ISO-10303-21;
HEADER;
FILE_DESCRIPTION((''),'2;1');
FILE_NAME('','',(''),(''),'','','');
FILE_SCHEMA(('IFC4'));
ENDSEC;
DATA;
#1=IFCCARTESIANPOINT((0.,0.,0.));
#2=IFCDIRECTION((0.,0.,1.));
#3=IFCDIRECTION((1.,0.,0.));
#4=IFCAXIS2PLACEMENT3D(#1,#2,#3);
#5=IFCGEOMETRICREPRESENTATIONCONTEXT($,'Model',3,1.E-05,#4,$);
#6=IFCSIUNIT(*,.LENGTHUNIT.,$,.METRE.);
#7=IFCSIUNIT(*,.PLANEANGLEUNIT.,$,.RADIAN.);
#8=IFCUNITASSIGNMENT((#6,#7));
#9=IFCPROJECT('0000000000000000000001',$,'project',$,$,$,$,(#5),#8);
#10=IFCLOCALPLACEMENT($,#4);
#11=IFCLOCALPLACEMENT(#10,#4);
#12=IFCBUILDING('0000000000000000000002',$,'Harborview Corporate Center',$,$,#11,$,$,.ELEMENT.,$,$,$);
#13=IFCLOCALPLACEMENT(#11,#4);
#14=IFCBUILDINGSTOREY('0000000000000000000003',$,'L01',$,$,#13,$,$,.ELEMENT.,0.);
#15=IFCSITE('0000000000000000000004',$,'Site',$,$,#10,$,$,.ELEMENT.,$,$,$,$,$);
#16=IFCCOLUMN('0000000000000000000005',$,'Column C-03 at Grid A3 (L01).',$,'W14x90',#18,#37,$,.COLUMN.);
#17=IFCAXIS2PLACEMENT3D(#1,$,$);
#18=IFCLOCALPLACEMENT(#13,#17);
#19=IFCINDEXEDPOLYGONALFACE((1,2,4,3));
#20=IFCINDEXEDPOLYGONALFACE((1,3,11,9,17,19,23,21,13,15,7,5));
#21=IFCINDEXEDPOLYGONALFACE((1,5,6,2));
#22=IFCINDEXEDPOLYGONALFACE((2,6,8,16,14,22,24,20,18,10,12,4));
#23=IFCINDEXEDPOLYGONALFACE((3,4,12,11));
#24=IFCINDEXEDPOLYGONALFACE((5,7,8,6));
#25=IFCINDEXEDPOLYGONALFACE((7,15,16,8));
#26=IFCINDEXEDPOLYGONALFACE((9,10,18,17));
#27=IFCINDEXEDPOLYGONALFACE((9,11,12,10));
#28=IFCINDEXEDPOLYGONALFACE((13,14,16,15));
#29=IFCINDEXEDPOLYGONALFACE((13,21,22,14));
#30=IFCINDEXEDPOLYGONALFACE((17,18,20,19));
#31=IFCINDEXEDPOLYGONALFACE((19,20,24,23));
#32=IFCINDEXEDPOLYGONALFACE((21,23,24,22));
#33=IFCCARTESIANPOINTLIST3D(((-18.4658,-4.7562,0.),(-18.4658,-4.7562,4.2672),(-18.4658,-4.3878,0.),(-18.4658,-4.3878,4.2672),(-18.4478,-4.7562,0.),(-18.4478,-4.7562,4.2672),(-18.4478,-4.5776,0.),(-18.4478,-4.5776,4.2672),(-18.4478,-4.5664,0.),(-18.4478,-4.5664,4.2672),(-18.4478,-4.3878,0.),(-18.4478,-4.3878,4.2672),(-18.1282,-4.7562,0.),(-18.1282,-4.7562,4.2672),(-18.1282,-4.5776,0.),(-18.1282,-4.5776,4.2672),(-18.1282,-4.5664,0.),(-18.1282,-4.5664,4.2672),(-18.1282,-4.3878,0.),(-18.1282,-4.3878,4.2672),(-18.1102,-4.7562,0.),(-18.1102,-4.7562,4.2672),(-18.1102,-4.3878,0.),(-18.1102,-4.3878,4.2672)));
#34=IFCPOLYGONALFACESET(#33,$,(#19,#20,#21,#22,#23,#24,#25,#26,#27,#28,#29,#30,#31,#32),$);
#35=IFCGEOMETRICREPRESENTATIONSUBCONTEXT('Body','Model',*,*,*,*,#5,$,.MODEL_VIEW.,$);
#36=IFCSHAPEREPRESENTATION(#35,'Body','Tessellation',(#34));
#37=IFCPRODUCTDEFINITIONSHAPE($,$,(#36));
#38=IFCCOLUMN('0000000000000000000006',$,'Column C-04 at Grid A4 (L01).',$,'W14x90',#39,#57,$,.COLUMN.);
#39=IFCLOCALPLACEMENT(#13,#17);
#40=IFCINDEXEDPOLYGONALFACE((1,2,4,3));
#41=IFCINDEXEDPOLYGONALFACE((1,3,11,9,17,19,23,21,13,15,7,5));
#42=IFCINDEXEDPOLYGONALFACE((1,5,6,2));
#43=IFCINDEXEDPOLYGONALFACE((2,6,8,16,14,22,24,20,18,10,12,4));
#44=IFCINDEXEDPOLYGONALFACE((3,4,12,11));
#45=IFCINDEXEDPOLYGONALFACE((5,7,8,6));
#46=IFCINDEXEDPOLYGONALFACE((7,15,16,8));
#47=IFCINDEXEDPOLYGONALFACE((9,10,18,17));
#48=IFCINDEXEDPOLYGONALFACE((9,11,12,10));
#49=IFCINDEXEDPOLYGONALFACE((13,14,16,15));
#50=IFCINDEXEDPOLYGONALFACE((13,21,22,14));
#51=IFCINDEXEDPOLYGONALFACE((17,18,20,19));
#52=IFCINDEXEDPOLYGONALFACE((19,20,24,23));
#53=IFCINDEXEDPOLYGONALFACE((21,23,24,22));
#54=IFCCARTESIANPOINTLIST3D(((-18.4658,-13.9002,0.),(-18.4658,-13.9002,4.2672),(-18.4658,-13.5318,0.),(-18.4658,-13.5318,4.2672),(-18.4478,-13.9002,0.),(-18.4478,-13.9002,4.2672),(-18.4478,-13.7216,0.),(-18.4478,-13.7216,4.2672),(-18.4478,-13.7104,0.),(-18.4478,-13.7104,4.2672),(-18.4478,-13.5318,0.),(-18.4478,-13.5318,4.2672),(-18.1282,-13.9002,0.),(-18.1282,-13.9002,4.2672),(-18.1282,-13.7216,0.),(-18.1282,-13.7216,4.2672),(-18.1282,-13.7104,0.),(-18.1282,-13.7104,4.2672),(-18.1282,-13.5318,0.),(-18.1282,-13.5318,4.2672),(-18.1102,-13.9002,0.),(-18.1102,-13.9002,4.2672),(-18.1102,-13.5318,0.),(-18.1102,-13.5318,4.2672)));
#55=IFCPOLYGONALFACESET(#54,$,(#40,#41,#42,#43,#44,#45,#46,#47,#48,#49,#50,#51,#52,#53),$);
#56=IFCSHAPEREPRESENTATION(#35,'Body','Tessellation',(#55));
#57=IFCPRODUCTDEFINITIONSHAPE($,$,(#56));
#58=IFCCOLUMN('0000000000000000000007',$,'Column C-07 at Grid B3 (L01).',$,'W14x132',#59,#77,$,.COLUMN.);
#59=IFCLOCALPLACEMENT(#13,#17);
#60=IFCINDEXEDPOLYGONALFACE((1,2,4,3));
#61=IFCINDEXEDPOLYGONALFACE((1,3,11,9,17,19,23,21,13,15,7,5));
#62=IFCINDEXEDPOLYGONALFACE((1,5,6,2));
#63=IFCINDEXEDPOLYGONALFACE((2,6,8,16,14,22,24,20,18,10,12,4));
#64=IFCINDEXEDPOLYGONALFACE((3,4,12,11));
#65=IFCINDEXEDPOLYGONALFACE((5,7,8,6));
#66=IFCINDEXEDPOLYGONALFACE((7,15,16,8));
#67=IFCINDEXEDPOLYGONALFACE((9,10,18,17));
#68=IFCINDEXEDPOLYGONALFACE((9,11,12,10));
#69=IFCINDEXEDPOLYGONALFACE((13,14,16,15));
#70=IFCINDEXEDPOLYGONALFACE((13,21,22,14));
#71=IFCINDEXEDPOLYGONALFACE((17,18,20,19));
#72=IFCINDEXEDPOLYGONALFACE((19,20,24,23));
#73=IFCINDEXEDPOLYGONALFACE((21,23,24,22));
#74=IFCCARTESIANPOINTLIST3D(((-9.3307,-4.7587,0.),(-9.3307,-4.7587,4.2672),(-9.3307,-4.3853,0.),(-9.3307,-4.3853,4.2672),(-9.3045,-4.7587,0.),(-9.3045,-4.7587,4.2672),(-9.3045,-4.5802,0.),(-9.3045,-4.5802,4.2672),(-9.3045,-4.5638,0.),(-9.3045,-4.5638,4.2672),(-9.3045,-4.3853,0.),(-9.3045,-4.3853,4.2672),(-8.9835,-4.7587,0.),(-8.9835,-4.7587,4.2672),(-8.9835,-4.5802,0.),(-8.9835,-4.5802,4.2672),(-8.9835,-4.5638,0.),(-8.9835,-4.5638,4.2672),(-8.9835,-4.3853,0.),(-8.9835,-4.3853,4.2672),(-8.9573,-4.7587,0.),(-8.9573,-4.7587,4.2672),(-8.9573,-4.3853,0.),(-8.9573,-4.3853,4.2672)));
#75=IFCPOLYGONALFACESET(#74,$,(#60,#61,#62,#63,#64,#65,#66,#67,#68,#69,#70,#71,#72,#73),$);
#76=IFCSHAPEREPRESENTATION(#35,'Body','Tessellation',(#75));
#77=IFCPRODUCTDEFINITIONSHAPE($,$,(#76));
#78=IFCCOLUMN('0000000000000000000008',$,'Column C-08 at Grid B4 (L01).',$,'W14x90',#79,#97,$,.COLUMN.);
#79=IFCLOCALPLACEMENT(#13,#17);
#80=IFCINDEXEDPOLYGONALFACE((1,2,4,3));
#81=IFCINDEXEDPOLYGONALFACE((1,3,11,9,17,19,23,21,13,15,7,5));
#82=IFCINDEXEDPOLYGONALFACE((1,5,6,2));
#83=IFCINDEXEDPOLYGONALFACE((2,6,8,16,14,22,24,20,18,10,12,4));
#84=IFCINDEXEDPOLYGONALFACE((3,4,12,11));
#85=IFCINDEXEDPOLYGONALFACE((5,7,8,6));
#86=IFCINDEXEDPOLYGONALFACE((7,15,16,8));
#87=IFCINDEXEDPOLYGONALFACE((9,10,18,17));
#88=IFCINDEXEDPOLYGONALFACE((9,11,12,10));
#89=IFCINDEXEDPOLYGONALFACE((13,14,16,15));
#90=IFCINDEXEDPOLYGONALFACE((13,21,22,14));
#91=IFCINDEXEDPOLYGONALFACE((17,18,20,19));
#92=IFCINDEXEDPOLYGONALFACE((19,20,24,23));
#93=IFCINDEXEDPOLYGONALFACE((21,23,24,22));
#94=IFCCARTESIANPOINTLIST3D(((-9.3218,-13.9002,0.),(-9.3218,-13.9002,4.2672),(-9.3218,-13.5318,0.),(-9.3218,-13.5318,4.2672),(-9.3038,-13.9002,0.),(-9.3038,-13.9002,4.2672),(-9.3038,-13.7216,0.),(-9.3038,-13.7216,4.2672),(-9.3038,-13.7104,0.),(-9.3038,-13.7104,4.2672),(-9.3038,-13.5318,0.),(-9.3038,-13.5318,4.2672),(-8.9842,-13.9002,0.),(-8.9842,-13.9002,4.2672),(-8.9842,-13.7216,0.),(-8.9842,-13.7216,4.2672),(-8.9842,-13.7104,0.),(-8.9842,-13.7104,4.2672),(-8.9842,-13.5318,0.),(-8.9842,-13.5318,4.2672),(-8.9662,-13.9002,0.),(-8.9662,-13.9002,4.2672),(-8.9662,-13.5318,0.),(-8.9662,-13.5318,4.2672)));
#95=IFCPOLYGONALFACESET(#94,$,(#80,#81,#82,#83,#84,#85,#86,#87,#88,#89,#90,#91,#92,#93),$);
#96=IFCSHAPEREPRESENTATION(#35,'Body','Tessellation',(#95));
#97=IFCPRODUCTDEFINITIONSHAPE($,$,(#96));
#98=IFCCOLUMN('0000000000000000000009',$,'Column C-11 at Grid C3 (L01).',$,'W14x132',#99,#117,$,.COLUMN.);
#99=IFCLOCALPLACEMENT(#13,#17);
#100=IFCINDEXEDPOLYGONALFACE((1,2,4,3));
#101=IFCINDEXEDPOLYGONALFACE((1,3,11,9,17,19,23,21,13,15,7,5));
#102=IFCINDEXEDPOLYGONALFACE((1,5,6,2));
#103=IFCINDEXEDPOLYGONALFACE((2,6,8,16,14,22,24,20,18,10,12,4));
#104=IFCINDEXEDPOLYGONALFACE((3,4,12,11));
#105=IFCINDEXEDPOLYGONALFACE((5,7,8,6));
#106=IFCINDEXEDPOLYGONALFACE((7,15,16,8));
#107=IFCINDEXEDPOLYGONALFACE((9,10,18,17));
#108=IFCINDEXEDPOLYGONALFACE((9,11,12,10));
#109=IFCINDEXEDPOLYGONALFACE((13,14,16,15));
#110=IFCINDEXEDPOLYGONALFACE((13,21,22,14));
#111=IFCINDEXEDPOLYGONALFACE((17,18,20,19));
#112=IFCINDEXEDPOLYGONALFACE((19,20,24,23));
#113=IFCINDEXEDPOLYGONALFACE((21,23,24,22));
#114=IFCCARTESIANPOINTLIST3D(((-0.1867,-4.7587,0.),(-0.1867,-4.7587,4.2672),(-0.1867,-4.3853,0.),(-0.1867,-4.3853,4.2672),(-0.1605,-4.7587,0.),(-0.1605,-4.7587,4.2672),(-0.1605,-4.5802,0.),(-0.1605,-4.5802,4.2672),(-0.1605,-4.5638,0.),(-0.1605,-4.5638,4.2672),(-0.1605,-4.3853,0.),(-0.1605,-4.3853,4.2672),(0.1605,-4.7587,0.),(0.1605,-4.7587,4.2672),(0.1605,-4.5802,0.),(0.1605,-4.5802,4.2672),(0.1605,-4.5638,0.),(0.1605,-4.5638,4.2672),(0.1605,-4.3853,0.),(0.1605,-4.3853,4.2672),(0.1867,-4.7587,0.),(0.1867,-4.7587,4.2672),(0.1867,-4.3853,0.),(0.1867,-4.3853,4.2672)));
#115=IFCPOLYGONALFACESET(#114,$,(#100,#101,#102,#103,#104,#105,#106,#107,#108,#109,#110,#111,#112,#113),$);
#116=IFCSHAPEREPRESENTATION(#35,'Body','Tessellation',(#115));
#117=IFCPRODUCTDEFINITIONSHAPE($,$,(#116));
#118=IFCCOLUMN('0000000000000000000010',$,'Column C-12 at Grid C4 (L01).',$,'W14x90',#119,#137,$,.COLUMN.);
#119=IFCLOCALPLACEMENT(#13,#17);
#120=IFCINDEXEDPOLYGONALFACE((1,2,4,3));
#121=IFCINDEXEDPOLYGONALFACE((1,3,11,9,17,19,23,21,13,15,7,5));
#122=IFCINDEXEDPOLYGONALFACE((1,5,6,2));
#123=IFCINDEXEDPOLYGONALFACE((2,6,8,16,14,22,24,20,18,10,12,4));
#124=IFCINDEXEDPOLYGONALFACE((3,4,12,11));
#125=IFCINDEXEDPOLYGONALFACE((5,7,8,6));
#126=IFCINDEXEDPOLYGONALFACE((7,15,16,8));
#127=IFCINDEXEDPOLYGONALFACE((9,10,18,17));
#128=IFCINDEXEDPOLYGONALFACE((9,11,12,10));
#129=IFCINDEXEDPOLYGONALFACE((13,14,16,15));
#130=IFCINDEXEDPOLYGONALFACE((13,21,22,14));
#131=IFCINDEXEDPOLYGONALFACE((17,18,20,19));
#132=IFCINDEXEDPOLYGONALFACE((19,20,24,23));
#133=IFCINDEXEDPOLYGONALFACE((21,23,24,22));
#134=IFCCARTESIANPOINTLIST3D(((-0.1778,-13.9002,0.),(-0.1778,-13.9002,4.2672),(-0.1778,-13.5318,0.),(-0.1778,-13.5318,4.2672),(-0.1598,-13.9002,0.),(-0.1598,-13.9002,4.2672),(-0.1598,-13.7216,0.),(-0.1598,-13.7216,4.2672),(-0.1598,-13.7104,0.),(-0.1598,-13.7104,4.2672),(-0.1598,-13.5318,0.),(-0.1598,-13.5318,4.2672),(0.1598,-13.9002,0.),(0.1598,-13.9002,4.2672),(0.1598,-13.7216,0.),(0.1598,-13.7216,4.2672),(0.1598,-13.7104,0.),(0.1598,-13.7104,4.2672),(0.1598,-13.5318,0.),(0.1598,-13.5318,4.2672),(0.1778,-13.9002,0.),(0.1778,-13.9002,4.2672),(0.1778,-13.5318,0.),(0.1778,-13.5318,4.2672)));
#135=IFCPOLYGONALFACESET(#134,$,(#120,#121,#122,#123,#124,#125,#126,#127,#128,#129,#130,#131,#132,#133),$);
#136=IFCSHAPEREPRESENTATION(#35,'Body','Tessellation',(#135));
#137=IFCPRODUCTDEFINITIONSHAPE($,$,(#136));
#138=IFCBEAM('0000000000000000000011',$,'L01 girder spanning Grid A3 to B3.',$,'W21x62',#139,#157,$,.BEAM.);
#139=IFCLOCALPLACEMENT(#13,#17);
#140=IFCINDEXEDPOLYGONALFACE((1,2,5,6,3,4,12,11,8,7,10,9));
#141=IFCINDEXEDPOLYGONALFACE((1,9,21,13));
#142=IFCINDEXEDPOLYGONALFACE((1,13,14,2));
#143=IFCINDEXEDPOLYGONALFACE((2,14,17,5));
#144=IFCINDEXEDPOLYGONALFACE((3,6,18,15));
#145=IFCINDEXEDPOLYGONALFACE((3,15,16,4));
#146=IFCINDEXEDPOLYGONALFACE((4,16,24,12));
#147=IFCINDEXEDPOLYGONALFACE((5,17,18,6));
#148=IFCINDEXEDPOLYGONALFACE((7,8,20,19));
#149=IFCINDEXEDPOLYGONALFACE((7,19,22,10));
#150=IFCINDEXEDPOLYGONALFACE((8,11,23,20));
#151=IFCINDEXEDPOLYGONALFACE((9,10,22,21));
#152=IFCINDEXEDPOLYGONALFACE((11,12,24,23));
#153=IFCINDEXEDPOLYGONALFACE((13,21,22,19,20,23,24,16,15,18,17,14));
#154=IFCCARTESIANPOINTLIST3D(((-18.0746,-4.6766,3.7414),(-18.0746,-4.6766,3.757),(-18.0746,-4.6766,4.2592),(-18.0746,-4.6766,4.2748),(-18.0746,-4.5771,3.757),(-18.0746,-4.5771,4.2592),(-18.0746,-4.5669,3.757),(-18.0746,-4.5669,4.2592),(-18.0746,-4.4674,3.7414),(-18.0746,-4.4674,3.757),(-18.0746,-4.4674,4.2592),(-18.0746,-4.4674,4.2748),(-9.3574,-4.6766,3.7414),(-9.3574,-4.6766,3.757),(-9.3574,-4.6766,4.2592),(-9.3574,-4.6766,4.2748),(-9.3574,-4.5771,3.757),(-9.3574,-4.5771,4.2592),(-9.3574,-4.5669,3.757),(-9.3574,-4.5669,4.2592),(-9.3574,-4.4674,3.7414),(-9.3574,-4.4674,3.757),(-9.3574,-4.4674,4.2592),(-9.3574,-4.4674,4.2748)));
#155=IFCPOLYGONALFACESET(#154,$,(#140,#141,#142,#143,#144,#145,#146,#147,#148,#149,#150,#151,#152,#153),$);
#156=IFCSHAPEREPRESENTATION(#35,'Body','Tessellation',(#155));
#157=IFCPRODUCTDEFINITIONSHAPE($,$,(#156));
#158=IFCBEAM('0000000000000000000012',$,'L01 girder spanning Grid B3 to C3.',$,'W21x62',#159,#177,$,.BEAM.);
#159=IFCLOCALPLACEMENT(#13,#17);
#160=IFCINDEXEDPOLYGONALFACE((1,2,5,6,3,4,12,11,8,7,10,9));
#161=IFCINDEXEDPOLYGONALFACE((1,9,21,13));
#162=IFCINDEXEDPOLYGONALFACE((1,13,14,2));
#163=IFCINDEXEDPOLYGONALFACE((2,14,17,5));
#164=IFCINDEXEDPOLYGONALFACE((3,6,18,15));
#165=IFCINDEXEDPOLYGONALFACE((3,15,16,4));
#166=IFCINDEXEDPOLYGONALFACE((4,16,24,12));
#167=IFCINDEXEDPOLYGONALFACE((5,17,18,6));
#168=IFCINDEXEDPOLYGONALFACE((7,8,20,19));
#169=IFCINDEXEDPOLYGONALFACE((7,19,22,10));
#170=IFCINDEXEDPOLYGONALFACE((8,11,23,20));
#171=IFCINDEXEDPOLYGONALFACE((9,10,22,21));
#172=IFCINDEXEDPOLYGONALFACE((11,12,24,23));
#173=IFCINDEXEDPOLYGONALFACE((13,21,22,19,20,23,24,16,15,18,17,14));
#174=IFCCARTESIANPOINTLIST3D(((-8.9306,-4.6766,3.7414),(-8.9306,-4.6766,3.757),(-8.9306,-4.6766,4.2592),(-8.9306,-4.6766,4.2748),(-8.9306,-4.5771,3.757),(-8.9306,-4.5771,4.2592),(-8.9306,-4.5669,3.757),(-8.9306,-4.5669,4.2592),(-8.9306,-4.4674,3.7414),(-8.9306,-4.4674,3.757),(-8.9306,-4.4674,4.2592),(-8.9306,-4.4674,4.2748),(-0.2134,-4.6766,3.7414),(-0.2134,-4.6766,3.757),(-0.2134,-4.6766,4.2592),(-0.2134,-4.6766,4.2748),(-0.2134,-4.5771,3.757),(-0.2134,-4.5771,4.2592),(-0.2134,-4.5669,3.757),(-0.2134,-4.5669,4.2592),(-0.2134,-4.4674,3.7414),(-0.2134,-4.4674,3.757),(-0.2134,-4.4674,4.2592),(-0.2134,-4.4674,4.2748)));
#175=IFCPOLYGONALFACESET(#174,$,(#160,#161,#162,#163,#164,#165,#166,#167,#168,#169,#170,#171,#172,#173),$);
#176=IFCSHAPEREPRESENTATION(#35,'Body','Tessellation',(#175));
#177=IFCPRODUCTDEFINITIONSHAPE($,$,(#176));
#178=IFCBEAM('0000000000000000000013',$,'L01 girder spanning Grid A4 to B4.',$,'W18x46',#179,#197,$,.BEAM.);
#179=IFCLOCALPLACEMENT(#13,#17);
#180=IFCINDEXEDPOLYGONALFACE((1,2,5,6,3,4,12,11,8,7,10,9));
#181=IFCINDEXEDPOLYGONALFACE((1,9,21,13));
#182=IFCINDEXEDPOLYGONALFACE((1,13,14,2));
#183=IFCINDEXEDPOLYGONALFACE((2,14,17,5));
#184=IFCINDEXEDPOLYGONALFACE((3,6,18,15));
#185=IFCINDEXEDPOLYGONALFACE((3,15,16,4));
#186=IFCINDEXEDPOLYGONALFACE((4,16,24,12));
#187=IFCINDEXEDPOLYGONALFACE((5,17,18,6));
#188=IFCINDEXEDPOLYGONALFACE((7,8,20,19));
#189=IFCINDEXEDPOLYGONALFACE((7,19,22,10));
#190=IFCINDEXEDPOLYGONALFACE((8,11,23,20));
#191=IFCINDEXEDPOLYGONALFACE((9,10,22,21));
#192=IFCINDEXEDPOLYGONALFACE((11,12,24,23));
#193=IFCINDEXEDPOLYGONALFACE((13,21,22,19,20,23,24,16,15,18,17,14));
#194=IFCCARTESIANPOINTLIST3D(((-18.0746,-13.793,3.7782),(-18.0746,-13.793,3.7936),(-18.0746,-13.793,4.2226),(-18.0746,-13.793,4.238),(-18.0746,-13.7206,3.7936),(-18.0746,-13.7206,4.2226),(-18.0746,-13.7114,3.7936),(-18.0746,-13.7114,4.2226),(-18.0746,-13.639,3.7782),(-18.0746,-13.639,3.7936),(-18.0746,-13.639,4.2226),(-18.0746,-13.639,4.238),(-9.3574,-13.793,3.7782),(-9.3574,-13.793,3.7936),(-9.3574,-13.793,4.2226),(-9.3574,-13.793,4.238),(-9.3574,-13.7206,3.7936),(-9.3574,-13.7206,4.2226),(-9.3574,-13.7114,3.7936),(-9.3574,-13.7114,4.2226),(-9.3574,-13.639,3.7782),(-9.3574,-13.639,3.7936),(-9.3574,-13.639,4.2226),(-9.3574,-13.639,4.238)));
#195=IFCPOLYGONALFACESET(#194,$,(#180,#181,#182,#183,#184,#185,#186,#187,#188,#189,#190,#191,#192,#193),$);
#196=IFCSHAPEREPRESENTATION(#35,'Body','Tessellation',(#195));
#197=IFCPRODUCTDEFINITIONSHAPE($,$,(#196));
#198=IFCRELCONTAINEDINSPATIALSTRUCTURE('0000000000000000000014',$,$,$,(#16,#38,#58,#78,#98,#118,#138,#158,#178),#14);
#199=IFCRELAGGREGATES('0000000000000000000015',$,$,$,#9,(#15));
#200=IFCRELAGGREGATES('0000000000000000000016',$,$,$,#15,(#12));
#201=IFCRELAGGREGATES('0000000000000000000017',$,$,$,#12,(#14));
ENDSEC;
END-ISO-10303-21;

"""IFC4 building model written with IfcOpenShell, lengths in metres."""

from ifc_helpers import new_model, si_unit, frame, origin_with_axes, place, context, subcontext, project, spatial, i_section, extrude, element, save


model = new_model("IFC4")

# Units and contexts
model_context = context("Model", 3, precision=1e-05, world=origin_with_axes())
body_context = subcontext(model_context, "Body", "Model", "MODEL_VIEW")
ifc_project = project(units=[si_unit("LENGTHUNIT", "METRE"), si_unit("PLANEANGLEUNIT", "RADIAN")], contexts=[model_context])

# Site, building, storey
site_placement = place(None, origin_with_axes())
site = spatial("IfcSite", under=ifc_project, at=site_placement, Name="Site", CompositionType="ELEMENT")
building_placement = place(site_placement, origin_with_axes())
building = spatial("IfcBuilding", under=site, at=building_placement, Name="Harborview Corporate Center", CompositionType="ELEMENT")
storey_placement = place(building_placement, origin_with_axes())
storey = spatial("IfcBuildingStorey", under=building, at=storey_placement, Name="L01", CompositionType="ELEMENT", Elevation=0.0)

# Columns
for number, where, z_axis, x_axis, name in (
    (1, (-18.288, -4.572, 0.0), (0.0, 0.0, 1.0), (0.0, 1.0, 0.0), "Column C-03 at Grid A3 (L01)."),
    (2, (-18.288, -13.716, 0.0), (0.0, 0.0, 1.0), (0.0, 1.0, 0.0), "Column C-04 at Grid A4 (L01)."),
):
    element("IfcColumn", number, at=place(storey_placement, frame(where, z_axis=z_axis, x_axis=x_axis)), inside=storey, Name=name, ObjectType="W14x90", PredefinedType="COLUMN", context=body_context, shape_type="SweptSolid", body=[
        extrude(i_section(OverallWidth=0.3683, OverallDepth=0.3556, WebThickness=0.0112, FlangeThickness=0.018), origin_with_axes(), (0.0, 0.0, 1.0), 4.2672),
    ])
column_1_placement = place(storey_placement, frame((-9.144, -4.572, 0.0), z_axis=(0.0, 0.0, 1.0), x_axis=(0.0, 1.0, 0.0)))
element("IfcColumn", 3, at=column_1_placement, inside=storey, Name="Column C-07 at Grid B3 (L01).", ObjectType="W14x132", PredefinedType="COLUMN", context=body_context, shape_type="SweptSolid", body=[
    extrude(i_section(OverallWidth=0.3734, OverallDepth=0.3734, WebThickness=0.0164, FlangeThickness=0.0262), origin_with_axes(), (0.0, 0.0, 1.0), 4.2672),
])
column_2_placement = place(storey_placement, frame((-9.144, -13.716, 0.0), z_axis=(0.0, 0.0, 1.0), x_axis=(0.0, 1.0, 0.0)))
element("IfcColumn", 4, at=column_2_placement, inside=storey, Name="Column C-08 at Grid B4 (L01).", ObjectType="W14x90", PredefinedType="COLUMN", context=body_context, shape_type="SweptSolid", body=[
    extrude(i_section(OverallWidth=0.3683, OverallDepth=0.3556, WebThickness=0.0112, FlangeThickness=0.018), origin_with_axes(), (0.0, 0.0, 1.0), 4.2672),
])
column_3_placement = place(storey_placement, frame((0.0, -4.572, 0.0), z_axis=(0.0, 0.0, 1.0), x_axis=(0.0, 1.0, 0.0)))
element("IfcColumn", 5, at=column_3_placement, inside=storey, Name="Column C-11 at Grid C3 (L01).", ObjectType="W14x132", PredefinedType="COLUMN", context=body_context, shape_type="SweptSolid", body=[
    extrude(i_section(OverallWidth=0.3734, OverallDepth=0.3734, WebThickness=0.0164, FlangeThickness=0.0262), origin_with_axes(), (0.0, 0.0, 1.0), 4.2672),
])
column_4_placement = place(storey_placement, frame((0.0, -13.716, 0.0), z_axis=(0.0, 0.0, 1.0), x_axis=(0.0, 1.0, 0.0)))
element("IfcColumn", 6, at=column_4_placement, inside=storey, Name="Column C-12 at Grid C4 (L01).", ObjectType="W14x90", PredefinedType="COLUMN", context=body_context, shape_type="SweptSolid", body=[
    extrude(i_section(OverallWidth=0.3683, OverallDepth=0.3556, WebThickness=0.0112, FlangeThickness=0.018), origin_with_axes(), (0.0, 0.0, 1.0), 4.2672),
])

# Beams
beam_1_placement = place(storey_placement, frame((-18.0746, -4.572, 4.0081), z_axis=(1.0, 0.0, 0.0), x_axis=(0.0, 1.0, 0.0)))
element("IfcBeam", 7, at=beam_1_placement, inside=storey, Name="L01 girder spanning Grid A3 to B3.", ObjectType="W21x62", PredefinedType="BEAM", context=body_context, shape_type="SweptSolid", body=[
    extrude(i_section(OverallWidth=0.2093, OverallDepth=0.5334, WebThickness=0.0102, FlangeThickness=0.0156), origin_with_axes(), (0.0, 0.0, 1.0), 8.7173),
])
beam_2_placement = place(storey_placement, frame((-8.9306, -4.572, 4.0081), z_axis=(1.0, 0.0, 0.0), x_axis=(0.0, 1.0, 0.0)))
element("IfcBeam", 8, at=beam_2_placement, inside=storey, Name="L01 girder spanning Grid B3 to C3.", ObjectType="W21x62", PredefinedType="BEAM", context=body_context, shape_type="SweptSolid", body=[
    extrude(i_section(OverallWidth=0.2093, OverallDepth=0.5334, WebThickness=0.0102, FlangeThickness=0.0156), origin_with_axes(), (0.0, 0.0, 1.0), 8.7173),
])
beam_3_placement = place(storey_placement, frame((-18.0746, -13.716, 4.0081), z_axis=(1.0, 0.0, 0.0), x_axis=(0.0, 1.0, 0.0)))
element("IfcBeam", 9, at=beam_3_placement, inside=storey, Name="L01 girder spanning Grid A4 to B4.", ObjectType="W18x46", PredefinedType="BEAM", context=body_context, shape_type="SweptSolid", body=[
    extrude(i_section(OverallWidth=0.1539, OverallDepth=0.4597, WebThickness=0.0091, FlangeThickness=0.0154), origin_with_axes(), (0.0, 0.0, 1.0), 8.7173),
])

save(model, "model.ifc")
